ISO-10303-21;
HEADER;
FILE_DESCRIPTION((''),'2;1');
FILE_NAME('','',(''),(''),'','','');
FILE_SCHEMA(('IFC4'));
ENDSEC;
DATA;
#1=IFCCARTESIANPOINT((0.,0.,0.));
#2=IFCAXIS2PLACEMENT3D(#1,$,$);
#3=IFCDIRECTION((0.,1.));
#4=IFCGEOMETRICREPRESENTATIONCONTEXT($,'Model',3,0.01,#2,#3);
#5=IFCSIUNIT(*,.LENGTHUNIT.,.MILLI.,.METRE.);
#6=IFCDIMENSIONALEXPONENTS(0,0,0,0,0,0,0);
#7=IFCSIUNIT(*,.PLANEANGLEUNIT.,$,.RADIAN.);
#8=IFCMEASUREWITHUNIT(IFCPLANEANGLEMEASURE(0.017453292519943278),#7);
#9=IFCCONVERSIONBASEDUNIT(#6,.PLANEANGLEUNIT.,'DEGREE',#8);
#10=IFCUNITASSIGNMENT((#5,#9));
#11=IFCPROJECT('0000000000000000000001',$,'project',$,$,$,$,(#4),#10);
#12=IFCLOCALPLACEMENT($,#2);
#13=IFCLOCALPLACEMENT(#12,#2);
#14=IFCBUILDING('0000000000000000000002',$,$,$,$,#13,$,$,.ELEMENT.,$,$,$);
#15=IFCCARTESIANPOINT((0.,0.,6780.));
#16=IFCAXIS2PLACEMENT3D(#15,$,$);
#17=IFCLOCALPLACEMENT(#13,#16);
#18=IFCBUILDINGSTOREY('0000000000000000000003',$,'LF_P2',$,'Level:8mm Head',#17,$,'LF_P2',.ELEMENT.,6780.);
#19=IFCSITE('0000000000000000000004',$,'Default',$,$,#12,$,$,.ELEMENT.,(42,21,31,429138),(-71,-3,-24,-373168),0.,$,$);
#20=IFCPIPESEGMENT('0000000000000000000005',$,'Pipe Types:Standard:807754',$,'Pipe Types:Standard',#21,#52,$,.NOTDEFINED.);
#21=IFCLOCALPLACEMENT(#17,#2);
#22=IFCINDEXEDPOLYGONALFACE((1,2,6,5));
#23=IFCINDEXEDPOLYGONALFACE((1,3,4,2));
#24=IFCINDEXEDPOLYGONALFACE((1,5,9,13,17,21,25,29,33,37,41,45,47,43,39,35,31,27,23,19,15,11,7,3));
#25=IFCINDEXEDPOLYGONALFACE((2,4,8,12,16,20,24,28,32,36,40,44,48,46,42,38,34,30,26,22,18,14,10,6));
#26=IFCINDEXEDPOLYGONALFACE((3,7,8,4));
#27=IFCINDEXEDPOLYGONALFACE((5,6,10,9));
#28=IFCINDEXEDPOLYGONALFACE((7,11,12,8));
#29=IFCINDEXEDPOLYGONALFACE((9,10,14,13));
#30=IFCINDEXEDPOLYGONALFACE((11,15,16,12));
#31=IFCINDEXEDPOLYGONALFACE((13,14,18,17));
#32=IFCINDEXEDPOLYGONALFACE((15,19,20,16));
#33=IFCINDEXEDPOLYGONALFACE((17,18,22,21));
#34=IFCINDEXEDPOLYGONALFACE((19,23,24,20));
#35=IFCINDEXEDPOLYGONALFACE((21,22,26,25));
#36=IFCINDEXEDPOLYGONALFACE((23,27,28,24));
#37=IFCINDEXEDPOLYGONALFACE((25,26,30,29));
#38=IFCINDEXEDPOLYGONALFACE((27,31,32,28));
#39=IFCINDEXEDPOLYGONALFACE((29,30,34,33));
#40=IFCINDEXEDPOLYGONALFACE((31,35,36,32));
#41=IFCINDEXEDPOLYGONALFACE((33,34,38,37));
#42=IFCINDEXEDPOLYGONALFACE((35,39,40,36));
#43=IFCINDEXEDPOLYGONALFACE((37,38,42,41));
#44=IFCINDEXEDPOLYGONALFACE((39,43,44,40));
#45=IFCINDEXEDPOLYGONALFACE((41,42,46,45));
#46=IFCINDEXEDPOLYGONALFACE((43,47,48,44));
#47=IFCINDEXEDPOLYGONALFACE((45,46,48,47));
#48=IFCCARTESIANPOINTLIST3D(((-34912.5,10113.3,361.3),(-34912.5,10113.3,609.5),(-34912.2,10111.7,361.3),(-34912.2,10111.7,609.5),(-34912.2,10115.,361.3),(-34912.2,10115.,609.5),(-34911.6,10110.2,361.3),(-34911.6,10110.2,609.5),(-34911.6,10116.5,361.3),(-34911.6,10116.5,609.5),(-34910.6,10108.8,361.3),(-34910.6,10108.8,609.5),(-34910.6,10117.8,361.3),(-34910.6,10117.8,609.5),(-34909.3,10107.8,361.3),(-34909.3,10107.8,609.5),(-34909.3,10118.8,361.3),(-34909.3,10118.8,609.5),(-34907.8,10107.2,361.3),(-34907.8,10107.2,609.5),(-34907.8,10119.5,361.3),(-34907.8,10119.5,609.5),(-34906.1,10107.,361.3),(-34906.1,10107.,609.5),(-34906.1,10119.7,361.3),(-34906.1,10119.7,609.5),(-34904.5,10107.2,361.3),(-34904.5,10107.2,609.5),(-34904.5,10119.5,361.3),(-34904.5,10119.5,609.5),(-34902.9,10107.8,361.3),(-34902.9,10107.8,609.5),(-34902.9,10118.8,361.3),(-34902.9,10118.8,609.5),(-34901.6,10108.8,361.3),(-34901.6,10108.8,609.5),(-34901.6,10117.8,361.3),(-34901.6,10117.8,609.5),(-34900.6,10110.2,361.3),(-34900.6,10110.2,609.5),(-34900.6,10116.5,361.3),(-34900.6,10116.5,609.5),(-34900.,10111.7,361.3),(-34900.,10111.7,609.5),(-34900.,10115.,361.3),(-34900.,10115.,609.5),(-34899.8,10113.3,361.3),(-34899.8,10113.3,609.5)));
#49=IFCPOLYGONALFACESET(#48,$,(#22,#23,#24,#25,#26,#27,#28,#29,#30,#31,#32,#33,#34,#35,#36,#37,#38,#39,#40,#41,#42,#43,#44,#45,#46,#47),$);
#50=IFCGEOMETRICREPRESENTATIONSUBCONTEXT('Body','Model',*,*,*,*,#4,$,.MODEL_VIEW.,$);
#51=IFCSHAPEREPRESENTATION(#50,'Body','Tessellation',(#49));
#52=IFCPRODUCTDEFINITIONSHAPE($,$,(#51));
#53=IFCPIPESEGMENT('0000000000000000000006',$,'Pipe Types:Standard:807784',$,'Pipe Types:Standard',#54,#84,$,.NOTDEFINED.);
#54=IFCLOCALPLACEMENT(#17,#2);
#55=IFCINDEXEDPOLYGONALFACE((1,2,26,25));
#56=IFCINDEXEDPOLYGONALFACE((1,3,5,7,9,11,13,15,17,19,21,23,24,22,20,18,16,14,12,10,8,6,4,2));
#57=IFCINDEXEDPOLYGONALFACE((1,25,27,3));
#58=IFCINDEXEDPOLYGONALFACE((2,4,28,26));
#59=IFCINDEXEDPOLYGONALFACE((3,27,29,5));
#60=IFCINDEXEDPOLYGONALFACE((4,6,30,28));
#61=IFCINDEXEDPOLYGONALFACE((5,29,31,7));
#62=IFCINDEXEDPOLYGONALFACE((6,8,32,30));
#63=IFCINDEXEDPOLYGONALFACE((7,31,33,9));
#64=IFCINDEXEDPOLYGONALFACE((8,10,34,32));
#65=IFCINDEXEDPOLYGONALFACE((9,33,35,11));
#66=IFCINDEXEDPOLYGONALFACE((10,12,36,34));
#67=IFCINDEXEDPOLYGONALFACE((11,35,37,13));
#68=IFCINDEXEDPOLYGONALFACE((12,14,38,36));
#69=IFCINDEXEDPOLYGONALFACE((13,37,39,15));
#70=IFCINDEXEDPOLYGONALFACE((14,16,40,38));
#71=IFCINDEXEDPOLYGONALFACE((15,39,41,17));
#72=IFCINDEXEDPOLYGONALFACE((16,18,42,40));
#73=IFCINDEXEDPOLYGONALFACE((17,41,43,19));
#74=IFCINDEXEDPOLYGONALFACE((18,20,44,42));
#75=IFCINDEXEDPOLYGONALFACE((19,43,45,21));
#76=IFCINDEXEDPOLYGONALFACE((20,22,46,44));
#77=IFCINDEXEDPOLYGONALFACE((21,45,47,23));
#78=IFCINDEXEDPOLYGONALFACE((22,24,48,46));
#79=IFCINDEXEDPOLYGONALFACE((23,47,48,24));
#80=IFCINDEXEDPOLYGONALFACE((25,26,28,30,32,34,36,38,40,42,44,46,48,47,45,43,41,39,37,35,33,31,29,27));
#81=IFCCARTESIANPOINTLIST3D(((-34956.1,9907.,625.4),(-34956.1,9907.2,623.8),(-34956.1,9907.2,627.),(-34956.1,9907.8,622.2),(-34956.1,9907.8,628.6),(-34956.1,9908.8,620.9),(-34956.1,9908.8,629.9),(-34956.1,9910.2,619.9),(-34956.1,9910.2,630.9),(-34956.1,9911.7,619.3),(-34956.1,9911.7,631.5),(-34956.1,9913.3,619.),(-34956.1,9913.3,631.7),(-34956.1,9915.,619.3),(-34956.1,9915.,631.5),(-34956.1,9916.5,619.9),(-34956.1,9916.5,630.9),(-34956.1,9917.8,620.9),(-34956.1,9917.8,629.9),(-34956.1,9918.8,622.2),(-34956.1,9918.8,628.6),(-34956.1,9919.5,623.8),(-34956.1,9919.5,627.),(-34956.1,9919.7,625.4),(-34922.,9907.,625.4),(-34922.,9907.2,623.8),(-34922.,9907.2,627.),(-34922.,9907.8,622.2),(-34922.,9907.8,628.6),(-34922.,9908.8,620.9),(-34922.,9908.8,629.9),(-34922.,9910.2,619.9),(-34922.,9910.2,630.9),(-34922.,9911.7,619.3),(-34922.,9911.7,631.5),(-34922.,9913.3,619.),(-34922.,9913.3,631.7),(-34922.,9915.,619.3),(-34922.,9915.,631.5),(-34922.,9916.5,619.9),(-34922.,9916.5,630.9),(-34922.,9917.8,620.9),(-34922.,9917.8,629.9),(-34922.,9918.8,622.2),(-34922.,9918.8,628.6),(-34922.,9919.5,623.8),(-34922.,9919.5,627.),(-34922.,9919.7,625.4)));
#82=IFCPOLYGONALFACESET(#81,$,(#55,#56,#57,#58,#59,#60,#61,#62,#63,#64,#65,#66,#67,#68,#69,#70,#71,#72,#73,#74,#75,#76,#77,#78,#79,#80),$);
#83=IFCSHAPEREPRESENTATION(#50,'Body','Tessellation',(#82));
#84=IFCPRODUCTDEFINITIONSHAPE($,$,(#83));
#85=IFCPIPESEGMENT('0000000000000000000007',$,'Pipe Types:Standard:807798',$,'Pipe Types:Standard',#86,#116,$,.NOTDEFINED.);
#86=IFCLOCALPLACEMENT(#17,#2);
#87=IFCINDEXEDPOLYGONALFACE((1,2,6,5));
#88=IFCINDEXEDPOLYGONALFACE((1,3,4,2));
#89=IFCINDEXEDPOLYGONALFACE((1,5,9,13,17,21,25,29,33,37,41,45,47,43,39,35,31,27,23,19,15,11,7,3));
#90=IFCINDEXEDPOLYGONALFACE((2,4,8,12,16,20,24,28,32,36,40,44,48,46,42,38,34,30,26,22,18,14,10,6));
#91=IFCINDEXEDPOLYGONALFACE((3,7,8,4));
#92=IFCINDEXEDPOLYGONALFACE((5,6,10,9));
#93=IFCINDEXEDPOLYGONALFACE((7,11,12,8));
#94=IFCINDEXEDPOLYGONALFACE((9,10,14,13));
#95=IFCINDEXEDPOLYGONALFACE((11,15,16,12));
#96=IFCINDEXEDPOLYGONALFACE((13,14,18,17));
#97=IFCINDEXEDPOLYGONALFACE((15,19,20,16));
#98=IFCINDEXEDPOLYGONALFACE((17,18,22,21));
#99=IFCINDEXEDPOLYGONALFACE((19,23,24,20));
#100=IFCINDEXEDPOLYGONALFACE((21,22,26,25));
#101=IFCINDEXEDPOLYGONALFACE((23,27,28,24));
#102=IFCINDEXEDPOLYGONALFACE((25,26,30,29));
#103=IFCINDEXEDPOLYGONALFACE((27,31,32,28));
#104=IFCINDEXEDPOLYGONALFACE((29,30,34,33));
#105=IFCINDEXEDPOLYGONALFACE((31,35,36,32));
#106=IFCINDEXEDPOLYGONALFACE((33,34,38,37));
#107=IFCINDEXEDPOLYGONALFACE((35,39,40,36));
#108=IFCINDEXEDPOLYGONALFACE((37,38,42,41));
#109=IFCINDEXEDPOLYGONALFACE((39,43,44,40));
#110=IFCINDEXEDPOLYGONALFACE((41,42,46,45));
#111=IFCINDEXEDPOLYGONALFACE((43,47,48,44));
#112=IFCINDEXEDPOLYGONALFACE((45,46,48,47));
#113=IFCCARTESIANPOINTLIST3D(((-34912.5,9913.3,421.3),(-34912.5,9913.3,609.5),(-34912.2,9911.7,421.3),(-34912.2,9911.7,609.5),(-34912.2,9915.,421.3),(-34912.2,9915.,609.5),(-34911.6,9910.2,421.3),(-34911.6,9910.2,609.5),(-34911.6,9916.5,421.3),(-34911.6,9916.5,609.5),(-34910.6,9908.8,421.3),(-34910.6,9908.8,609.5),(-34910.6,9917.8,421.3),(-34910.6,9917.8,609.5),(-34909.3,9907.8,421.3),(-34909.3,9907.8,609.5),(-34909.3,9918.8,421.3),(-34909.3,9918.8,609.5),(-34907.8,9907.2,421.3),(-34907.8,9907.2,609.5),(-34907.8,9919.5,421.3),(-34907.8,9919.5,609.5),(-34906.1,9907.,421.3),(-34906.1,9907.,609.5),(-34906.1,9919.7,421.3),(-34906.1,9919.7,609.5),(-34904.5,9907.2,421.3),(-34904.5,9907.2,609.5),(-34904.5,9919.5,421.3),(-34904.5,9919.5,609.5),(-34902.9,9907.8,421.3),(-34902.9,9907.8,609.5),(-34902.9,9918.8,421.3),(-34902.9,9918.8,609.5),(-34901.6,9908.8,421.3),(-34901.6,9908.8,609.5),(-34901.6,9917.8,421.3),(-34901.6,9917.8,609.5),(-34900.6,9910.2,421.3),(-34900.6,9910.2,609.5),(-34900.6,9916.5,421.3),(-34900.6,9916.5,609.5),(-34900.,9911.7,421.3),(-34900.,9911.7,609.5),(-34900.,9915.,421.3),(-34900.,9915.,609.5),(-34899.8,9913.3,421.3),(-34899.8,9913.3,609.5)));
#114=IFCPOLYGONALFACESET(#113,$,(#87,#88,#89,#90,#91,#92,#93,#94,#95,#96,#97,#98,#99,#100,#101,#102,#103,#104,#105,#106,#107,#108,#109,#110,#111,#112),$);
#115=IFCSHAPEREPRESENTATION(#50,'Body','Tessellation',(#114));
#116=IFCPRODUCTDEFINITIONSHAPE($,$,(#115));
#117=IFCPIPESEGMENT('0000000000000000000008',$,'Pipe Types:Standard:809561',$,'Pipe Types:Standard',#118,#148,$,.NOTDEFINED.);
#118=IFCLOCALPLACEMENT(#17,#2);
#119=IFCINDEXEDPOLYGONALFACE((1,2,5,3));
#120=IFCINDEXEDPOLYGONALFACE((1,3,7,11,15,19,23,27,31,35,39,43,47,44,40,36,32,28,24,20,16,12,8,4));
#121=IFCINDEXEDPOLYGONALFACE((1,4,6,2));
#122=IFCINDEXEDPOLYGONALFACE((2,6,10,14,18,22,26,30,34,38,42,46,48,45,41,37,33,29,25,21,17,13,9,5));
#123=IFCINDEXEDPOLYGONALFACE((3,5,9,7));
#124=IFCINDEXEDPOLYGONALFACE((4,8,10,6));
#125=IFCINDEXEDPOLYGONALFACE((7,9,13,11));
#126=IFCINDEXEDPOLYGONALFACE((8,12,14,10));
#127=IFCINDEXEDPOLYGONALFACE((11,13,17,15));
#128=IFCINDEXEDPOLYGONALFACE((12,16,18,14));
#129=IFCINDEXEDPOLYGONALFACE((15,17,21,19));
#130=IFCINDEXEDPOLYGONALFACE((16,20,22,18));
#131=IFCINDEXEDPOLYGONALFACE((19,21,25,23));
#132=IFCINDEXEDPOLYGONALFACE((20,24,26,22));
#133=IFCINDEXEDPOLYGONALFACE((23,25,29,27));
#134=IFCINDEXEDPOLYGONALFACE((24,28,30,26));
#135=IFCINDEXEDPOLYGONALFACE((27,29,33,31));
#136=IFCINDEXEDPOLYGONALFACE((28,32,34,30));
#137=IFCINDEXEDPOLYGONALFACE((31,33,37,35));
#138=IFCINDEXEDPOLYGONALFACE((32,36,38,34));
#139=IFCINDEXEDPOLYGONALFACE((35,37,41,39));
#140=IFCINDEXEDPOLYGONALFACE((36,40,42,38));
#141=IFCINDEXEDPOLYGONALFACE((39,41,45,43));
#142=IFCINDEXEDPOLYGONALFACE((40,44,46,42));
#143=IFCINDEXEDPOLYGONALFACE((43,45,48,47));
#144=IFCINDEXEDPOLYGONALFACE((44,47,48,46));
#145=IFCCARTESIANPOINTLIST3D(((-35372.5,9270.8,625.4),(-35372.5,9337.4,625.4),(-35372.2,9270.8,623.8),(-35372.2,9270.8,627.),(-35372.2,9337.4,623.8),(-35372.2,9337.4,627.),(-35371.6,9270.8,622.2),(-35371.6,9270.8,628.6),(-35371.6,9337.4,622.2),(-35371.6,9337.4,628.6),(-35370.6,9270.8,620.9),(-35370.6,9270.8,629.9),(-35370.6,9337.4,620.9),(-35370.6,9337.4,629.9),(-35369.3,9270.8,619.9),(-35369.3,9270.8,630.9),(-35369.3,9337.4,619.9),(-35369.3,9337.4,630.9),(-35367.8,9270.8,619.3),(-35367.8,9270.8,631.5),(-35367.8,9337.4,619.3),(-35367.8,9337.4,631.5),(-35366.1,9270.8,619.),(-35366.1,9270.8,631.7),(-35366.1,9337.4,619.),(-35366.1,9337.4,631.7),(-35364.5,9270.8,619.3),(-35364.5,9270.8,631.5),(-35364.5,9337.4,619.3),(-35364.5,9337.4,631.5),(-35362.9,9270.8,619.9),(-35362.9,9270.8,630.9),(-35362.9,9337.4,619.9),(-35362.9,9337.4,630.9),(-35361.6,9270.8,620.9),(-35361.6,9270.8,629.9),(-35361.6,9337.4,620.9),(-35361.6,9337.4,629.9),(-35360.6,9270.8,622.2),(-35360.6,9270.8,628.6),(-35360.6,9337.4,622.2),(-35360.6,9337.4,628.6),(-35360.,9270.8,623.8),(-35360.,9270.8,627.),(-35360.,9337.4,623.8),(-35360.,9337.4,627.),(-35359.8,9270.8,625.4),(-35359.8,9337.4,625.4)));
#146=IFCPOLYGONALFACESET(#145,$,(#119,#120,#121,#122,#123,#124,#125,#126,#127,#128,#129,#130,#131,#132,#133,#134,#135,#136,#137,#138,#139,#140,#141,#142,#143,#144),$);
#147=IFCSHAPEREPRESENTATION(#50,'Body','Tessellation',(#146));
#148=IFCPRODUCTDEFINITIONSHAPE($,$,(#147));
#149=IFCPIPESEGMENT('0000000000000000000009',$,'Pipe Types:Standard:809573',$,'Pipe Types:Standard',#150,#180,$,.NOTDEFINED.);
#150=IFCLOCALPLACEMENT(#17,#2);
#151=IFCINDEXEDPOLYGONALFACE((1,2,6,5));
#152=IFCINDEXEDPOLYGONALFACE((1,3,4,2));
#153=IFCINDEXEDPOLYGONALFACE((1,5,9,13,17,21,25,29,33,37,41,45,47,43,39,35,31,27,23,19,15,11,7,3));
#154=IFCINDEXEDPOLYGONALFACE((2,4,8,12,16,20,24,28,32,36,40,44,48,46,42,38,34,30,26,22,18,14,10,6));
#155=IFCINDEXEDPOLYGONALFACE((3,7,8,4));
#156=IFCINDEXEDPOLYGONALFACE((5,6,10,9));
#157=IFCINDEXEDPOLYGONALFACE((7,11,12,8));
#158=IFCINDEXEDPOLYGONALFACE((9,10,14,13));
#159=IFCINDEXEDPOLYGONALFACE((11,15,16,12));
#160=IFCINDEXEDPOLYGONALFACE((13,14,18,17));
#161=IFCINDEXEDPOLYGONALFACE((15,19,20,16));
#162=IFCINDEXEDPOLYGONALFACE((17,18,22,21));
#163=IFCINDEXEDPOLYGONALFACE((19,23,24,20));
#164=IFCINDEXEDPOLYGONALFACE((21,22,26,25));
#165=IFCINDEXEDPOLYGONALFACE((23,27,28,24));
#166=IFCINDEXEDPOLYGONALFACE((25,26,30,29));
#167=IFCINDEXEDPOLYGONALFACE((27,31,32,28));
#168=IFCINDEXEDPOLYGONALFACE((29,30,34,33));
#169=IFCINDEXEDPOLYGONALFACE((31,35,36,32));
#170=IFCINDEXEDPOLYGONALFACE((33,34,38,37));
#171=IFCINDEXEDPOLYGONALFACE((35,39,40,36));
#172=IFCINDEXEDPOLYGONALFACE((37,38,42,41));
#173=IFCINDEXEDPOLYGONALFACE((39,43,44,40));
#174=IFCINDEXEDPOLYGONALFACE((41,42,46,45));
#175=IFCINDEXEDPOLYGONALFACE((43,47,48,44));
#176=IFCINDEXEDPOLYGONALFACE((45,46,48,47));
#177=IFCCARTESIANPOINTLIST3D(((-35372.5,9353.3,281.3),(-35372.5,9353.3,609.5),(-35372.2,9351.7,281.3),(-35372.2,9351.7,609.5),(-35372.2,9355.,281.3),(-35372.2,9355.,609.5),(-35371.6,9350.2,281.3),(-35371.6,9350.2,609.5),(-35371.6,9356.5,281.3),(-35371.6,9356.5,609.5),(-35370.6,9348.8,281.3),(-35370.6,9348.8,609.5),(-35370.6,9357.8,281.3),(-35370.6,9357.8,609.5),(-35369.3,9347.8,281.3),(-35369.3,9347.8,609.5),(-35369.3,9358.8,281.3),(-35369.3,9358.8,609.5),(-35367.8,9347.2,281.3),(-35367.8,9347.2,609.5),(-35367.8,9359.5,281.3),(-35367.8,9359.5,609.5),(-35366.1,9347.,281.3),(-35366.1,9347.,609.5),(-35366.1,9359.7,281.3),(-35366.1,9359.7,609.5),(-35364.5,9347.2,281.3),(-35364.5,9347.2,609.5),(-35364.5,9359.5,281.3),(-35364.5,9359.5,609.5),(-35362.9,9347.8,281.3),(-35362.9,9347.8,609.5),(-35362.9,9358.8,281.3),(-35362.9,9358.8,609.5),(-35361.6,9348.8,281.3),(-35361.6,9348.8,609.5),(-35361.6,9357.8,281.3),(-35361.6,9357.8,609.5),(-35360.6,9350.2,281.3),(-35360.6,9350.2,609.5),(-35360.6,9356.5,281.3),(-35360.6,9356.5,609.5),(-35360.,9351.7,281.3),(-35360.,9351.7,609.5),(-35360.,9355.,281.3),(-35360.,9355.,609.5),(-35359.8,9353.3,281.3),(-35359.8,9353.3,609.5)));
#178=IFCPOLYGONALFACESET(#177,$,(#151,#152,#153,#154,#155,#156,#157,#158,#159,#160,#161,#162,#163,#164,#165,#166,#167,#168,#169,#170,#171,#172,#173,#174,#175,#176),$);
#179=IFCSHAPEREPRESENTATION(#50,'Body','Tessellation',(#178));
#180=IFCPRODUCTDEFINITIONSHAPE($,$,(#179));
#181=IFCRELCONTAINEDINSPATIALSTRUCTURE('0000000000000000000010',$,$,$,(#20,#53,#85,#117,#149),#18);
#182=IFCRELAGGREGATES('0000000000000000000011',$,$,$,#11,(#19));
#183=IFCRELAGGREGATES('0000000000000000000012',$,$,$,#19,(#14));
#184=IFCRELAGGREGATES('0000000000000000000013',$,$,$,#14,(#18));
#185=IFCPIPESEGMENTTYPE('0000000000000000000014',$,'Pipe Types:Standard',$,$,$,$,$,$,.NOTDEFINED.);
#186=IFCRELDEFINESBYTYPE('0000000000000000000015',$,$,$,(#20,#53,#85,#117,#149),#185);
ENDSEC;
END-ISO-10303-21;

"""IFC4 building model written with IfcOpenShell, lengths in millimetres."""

from ifc_helpers import new_model, entity, si_unit, converted_unit, direction, frame, origin, place, context, subcontext, project, spatial, arc, indexed_curve, outline, extrude, type_object, element, save


model = new_model("IFC4")

# Units and contexts
model_context = context("Model", 3, precision=0.01, world=origin(), true_north=direction((0.0, 1.0)))
body_context = subcontext(model_context, "Body", "Model", "MODEL_VIEW")
ifc_project = project(units=[si_unit("LENGTHUNIT", "METRE", prefix="MILLI"), converted_unit("PLANEANGLEUNIT", "DEGREE", entity("IfcPlaneAngleMeasure", 0.017453292519943278), si_unit("PLANEANGLEUNIT", "RADIAN"), dimensions=[0, 0, 0, 0, 0, 0, 0])], contexts=[model_context])

# Site, building, storey
site_placement = place(None, origin())
site = spatial("IfcSite", under=ifc_project, at=site_placement, Name="Default", CompositionType="ELEMENT", RefLatitude=(42, 21, 31, 429138), RefLongitude=(-71, -3, -24, -373168), RefElevation=0.0)
building_placement = place(site_placement, origin())
building = spatial("IfcBuilding", under=site, at=building_placement, CompositionType="ELEMENT")
storey_placement = place(building_placement, frame((0.0, 0.0, 6780.0)))
storey = spatial("IfcBuildingStorey", under=building, at=storey_placement, Name="LF_P2", ObjectType="Level:8mm Head", LongName="LF_P2", CompositionType="ELEMENT", Elevation=6780.0)

# Pipe segments
pipe_segment_type_1 = type_object("IfcPipeSegmentType", Name="Pipe Types:Standard", PredefinedType="NOTDEFINED")
pipe_segment_1_placement = place(storey_placement, origin())
element("IfcPipeSegment", 1, at=pipe_segment_1_placement, inside=storey, type_object=pipe_segment_type_1, Name="Pipe Types:Standard:807754", ObjectType="Pipe Types:Standard", PredefinedType="NOTDEFINED", context=body_context, shape_type="SweptSolid", body=[
    extrude(outline(indexed_curve([(6.3, 0.0), (4.5, 4.5), (0.0, 6.4), (-4.5, 4.5), (-6.3, 0.0), (-4.5, -4.5), (0.0, -6.4), (4.5, -4.5)], segments=[arc(1, 2, 3), arc(3, 4, 5), arc(5, 6, 7), arc(7, 8, 1)], self_intersect=False)), frame((-34906.1, 10113.3, 361.3)), (0.0, 0.0, 1.0), 248.2),
])
pipe_segment_2_placement = place(storey_placement, origin())
element("IfcPipeSegment", 2, at=pipe_segment_2_placement, inside=storey, type_object=pipe_segment_type_1, Name="Pipe Types:Standard:807784", ObjectType="Pipe Types:Standard", PredefinedType="NOTDEFINED", context=body_context, shape_type="SweptSolid", body=[
    extrude(outline(indexed_curve([(6.4, 0.0), (4.5, 4.5), (0.0, 6.3), (-4.5, 4.5), (-6.4, 0.0), (-4.5, -4.5), (0.0, -6.3), (4.5, -4.5)], segments=[arc(1, 2, 3), arc(3, 4, 5), arc(5, 6, 7), arc(7, 8, 1)], self_intersect=False)), frame((-34956.1, 9913.3, 625.4), z_axis=(1.0, 0.0, 0.0), x_axis=(0.0, -1.0, 0.0)), (0.0, 0.0, 1.0), 34.1),
])
pipe_segment_3_placement = place(storey_placement, origin())
element("IfcPipeSegment", 3, at=pipe_segment_3_placement, inside=storey, type_object=pipe_segment_type_1, Name="Pipe Types:Standard:807798", ObjectType="Pipe Types:Standard", PredefinedType="NOTDEFINED", context=body_context, shape_type="SweptSolid", body=[
    extrude(outline(indexed_curve([(6.3, 0.0), (4.5, 4.5), (0.0, 6.4), (-4.5, 4.5), (-6.3, 0.0), (-4.5, -4.5), (0.0, -6.4), (4.5, -4.5)], segments=[arc(1, 2, 3), arc(3, 4, 5), arc(5, 6, 7), arc(7, 8, 1)], self_intersect=False)), frame((-34906.1, 9913.3, 421.3)), (0.0, 0.0, 1.0), 188.2),
])
pipe_segment_4_placement = place(storey_placement, origin())
element("IfcPipeSegment", 4, at=pipe_segment_4_placement, inside=storey, type_object=pipe_segment_type_1, Name="Pipe Types:Standard:809561", ObjectType="Pipe Types:Standard", PredefinedType="NOTDEFINED", context=body_context, shape_type="SweptSolid", body=[
    extrude(outline(indexed_curve([(6.3, 0.0), (4.5, 4.5), (0.0, 6.3), (-4.5, 4.5), (-6.3, 0.0), (-4.5, -4.5), (0.0, -6.3), (4.5, -4.5)], segments=[arc(1, 2, 3), arc(3, 4, 5), arc(5, 6, 7), arc(7, 8, 1)], self_intersect=False)), frame((-35366.1, 9270.8, 625.4), z_axis=(0.0, 1.0, 0.0), x_axis=(1.0, 0.0, 0.0)), (0.0, 0.0, 1.0), 66.6),
])
pipe_segment_5_placement = place(storey_placement, origin())
element("IfcPipeSegment", 5, at=pipe_segment_5_placement, inside=storey, type_object=pipe_segment_type_1, Name="Pipe Types:Standard:809573", ObjectType="Pipe Types:Standard", PredefinedType="NOTDEFINED", context=body_context, shape_type="SweptSolid", body=[
    extrude(outline(indexed_curve([(6.3, 0.0), (4.5, 4.5), (0.0, 6.3), (-4.5, 4.5), (-6.3, 0.0), (-4.5, -4.5), (0.0, -6.4), (4.5, -4.5)], segments=[arc(1, 2, 3), arc(3, 4, 5), arc(5, 6, 7), arc(7, 8, 1)], self_intersect=False)), frame((-35366.1, 9353.3, 281.3)), (0.0, 0.0, 1.0), 328.2),
])

save(model, "model.ifc")
